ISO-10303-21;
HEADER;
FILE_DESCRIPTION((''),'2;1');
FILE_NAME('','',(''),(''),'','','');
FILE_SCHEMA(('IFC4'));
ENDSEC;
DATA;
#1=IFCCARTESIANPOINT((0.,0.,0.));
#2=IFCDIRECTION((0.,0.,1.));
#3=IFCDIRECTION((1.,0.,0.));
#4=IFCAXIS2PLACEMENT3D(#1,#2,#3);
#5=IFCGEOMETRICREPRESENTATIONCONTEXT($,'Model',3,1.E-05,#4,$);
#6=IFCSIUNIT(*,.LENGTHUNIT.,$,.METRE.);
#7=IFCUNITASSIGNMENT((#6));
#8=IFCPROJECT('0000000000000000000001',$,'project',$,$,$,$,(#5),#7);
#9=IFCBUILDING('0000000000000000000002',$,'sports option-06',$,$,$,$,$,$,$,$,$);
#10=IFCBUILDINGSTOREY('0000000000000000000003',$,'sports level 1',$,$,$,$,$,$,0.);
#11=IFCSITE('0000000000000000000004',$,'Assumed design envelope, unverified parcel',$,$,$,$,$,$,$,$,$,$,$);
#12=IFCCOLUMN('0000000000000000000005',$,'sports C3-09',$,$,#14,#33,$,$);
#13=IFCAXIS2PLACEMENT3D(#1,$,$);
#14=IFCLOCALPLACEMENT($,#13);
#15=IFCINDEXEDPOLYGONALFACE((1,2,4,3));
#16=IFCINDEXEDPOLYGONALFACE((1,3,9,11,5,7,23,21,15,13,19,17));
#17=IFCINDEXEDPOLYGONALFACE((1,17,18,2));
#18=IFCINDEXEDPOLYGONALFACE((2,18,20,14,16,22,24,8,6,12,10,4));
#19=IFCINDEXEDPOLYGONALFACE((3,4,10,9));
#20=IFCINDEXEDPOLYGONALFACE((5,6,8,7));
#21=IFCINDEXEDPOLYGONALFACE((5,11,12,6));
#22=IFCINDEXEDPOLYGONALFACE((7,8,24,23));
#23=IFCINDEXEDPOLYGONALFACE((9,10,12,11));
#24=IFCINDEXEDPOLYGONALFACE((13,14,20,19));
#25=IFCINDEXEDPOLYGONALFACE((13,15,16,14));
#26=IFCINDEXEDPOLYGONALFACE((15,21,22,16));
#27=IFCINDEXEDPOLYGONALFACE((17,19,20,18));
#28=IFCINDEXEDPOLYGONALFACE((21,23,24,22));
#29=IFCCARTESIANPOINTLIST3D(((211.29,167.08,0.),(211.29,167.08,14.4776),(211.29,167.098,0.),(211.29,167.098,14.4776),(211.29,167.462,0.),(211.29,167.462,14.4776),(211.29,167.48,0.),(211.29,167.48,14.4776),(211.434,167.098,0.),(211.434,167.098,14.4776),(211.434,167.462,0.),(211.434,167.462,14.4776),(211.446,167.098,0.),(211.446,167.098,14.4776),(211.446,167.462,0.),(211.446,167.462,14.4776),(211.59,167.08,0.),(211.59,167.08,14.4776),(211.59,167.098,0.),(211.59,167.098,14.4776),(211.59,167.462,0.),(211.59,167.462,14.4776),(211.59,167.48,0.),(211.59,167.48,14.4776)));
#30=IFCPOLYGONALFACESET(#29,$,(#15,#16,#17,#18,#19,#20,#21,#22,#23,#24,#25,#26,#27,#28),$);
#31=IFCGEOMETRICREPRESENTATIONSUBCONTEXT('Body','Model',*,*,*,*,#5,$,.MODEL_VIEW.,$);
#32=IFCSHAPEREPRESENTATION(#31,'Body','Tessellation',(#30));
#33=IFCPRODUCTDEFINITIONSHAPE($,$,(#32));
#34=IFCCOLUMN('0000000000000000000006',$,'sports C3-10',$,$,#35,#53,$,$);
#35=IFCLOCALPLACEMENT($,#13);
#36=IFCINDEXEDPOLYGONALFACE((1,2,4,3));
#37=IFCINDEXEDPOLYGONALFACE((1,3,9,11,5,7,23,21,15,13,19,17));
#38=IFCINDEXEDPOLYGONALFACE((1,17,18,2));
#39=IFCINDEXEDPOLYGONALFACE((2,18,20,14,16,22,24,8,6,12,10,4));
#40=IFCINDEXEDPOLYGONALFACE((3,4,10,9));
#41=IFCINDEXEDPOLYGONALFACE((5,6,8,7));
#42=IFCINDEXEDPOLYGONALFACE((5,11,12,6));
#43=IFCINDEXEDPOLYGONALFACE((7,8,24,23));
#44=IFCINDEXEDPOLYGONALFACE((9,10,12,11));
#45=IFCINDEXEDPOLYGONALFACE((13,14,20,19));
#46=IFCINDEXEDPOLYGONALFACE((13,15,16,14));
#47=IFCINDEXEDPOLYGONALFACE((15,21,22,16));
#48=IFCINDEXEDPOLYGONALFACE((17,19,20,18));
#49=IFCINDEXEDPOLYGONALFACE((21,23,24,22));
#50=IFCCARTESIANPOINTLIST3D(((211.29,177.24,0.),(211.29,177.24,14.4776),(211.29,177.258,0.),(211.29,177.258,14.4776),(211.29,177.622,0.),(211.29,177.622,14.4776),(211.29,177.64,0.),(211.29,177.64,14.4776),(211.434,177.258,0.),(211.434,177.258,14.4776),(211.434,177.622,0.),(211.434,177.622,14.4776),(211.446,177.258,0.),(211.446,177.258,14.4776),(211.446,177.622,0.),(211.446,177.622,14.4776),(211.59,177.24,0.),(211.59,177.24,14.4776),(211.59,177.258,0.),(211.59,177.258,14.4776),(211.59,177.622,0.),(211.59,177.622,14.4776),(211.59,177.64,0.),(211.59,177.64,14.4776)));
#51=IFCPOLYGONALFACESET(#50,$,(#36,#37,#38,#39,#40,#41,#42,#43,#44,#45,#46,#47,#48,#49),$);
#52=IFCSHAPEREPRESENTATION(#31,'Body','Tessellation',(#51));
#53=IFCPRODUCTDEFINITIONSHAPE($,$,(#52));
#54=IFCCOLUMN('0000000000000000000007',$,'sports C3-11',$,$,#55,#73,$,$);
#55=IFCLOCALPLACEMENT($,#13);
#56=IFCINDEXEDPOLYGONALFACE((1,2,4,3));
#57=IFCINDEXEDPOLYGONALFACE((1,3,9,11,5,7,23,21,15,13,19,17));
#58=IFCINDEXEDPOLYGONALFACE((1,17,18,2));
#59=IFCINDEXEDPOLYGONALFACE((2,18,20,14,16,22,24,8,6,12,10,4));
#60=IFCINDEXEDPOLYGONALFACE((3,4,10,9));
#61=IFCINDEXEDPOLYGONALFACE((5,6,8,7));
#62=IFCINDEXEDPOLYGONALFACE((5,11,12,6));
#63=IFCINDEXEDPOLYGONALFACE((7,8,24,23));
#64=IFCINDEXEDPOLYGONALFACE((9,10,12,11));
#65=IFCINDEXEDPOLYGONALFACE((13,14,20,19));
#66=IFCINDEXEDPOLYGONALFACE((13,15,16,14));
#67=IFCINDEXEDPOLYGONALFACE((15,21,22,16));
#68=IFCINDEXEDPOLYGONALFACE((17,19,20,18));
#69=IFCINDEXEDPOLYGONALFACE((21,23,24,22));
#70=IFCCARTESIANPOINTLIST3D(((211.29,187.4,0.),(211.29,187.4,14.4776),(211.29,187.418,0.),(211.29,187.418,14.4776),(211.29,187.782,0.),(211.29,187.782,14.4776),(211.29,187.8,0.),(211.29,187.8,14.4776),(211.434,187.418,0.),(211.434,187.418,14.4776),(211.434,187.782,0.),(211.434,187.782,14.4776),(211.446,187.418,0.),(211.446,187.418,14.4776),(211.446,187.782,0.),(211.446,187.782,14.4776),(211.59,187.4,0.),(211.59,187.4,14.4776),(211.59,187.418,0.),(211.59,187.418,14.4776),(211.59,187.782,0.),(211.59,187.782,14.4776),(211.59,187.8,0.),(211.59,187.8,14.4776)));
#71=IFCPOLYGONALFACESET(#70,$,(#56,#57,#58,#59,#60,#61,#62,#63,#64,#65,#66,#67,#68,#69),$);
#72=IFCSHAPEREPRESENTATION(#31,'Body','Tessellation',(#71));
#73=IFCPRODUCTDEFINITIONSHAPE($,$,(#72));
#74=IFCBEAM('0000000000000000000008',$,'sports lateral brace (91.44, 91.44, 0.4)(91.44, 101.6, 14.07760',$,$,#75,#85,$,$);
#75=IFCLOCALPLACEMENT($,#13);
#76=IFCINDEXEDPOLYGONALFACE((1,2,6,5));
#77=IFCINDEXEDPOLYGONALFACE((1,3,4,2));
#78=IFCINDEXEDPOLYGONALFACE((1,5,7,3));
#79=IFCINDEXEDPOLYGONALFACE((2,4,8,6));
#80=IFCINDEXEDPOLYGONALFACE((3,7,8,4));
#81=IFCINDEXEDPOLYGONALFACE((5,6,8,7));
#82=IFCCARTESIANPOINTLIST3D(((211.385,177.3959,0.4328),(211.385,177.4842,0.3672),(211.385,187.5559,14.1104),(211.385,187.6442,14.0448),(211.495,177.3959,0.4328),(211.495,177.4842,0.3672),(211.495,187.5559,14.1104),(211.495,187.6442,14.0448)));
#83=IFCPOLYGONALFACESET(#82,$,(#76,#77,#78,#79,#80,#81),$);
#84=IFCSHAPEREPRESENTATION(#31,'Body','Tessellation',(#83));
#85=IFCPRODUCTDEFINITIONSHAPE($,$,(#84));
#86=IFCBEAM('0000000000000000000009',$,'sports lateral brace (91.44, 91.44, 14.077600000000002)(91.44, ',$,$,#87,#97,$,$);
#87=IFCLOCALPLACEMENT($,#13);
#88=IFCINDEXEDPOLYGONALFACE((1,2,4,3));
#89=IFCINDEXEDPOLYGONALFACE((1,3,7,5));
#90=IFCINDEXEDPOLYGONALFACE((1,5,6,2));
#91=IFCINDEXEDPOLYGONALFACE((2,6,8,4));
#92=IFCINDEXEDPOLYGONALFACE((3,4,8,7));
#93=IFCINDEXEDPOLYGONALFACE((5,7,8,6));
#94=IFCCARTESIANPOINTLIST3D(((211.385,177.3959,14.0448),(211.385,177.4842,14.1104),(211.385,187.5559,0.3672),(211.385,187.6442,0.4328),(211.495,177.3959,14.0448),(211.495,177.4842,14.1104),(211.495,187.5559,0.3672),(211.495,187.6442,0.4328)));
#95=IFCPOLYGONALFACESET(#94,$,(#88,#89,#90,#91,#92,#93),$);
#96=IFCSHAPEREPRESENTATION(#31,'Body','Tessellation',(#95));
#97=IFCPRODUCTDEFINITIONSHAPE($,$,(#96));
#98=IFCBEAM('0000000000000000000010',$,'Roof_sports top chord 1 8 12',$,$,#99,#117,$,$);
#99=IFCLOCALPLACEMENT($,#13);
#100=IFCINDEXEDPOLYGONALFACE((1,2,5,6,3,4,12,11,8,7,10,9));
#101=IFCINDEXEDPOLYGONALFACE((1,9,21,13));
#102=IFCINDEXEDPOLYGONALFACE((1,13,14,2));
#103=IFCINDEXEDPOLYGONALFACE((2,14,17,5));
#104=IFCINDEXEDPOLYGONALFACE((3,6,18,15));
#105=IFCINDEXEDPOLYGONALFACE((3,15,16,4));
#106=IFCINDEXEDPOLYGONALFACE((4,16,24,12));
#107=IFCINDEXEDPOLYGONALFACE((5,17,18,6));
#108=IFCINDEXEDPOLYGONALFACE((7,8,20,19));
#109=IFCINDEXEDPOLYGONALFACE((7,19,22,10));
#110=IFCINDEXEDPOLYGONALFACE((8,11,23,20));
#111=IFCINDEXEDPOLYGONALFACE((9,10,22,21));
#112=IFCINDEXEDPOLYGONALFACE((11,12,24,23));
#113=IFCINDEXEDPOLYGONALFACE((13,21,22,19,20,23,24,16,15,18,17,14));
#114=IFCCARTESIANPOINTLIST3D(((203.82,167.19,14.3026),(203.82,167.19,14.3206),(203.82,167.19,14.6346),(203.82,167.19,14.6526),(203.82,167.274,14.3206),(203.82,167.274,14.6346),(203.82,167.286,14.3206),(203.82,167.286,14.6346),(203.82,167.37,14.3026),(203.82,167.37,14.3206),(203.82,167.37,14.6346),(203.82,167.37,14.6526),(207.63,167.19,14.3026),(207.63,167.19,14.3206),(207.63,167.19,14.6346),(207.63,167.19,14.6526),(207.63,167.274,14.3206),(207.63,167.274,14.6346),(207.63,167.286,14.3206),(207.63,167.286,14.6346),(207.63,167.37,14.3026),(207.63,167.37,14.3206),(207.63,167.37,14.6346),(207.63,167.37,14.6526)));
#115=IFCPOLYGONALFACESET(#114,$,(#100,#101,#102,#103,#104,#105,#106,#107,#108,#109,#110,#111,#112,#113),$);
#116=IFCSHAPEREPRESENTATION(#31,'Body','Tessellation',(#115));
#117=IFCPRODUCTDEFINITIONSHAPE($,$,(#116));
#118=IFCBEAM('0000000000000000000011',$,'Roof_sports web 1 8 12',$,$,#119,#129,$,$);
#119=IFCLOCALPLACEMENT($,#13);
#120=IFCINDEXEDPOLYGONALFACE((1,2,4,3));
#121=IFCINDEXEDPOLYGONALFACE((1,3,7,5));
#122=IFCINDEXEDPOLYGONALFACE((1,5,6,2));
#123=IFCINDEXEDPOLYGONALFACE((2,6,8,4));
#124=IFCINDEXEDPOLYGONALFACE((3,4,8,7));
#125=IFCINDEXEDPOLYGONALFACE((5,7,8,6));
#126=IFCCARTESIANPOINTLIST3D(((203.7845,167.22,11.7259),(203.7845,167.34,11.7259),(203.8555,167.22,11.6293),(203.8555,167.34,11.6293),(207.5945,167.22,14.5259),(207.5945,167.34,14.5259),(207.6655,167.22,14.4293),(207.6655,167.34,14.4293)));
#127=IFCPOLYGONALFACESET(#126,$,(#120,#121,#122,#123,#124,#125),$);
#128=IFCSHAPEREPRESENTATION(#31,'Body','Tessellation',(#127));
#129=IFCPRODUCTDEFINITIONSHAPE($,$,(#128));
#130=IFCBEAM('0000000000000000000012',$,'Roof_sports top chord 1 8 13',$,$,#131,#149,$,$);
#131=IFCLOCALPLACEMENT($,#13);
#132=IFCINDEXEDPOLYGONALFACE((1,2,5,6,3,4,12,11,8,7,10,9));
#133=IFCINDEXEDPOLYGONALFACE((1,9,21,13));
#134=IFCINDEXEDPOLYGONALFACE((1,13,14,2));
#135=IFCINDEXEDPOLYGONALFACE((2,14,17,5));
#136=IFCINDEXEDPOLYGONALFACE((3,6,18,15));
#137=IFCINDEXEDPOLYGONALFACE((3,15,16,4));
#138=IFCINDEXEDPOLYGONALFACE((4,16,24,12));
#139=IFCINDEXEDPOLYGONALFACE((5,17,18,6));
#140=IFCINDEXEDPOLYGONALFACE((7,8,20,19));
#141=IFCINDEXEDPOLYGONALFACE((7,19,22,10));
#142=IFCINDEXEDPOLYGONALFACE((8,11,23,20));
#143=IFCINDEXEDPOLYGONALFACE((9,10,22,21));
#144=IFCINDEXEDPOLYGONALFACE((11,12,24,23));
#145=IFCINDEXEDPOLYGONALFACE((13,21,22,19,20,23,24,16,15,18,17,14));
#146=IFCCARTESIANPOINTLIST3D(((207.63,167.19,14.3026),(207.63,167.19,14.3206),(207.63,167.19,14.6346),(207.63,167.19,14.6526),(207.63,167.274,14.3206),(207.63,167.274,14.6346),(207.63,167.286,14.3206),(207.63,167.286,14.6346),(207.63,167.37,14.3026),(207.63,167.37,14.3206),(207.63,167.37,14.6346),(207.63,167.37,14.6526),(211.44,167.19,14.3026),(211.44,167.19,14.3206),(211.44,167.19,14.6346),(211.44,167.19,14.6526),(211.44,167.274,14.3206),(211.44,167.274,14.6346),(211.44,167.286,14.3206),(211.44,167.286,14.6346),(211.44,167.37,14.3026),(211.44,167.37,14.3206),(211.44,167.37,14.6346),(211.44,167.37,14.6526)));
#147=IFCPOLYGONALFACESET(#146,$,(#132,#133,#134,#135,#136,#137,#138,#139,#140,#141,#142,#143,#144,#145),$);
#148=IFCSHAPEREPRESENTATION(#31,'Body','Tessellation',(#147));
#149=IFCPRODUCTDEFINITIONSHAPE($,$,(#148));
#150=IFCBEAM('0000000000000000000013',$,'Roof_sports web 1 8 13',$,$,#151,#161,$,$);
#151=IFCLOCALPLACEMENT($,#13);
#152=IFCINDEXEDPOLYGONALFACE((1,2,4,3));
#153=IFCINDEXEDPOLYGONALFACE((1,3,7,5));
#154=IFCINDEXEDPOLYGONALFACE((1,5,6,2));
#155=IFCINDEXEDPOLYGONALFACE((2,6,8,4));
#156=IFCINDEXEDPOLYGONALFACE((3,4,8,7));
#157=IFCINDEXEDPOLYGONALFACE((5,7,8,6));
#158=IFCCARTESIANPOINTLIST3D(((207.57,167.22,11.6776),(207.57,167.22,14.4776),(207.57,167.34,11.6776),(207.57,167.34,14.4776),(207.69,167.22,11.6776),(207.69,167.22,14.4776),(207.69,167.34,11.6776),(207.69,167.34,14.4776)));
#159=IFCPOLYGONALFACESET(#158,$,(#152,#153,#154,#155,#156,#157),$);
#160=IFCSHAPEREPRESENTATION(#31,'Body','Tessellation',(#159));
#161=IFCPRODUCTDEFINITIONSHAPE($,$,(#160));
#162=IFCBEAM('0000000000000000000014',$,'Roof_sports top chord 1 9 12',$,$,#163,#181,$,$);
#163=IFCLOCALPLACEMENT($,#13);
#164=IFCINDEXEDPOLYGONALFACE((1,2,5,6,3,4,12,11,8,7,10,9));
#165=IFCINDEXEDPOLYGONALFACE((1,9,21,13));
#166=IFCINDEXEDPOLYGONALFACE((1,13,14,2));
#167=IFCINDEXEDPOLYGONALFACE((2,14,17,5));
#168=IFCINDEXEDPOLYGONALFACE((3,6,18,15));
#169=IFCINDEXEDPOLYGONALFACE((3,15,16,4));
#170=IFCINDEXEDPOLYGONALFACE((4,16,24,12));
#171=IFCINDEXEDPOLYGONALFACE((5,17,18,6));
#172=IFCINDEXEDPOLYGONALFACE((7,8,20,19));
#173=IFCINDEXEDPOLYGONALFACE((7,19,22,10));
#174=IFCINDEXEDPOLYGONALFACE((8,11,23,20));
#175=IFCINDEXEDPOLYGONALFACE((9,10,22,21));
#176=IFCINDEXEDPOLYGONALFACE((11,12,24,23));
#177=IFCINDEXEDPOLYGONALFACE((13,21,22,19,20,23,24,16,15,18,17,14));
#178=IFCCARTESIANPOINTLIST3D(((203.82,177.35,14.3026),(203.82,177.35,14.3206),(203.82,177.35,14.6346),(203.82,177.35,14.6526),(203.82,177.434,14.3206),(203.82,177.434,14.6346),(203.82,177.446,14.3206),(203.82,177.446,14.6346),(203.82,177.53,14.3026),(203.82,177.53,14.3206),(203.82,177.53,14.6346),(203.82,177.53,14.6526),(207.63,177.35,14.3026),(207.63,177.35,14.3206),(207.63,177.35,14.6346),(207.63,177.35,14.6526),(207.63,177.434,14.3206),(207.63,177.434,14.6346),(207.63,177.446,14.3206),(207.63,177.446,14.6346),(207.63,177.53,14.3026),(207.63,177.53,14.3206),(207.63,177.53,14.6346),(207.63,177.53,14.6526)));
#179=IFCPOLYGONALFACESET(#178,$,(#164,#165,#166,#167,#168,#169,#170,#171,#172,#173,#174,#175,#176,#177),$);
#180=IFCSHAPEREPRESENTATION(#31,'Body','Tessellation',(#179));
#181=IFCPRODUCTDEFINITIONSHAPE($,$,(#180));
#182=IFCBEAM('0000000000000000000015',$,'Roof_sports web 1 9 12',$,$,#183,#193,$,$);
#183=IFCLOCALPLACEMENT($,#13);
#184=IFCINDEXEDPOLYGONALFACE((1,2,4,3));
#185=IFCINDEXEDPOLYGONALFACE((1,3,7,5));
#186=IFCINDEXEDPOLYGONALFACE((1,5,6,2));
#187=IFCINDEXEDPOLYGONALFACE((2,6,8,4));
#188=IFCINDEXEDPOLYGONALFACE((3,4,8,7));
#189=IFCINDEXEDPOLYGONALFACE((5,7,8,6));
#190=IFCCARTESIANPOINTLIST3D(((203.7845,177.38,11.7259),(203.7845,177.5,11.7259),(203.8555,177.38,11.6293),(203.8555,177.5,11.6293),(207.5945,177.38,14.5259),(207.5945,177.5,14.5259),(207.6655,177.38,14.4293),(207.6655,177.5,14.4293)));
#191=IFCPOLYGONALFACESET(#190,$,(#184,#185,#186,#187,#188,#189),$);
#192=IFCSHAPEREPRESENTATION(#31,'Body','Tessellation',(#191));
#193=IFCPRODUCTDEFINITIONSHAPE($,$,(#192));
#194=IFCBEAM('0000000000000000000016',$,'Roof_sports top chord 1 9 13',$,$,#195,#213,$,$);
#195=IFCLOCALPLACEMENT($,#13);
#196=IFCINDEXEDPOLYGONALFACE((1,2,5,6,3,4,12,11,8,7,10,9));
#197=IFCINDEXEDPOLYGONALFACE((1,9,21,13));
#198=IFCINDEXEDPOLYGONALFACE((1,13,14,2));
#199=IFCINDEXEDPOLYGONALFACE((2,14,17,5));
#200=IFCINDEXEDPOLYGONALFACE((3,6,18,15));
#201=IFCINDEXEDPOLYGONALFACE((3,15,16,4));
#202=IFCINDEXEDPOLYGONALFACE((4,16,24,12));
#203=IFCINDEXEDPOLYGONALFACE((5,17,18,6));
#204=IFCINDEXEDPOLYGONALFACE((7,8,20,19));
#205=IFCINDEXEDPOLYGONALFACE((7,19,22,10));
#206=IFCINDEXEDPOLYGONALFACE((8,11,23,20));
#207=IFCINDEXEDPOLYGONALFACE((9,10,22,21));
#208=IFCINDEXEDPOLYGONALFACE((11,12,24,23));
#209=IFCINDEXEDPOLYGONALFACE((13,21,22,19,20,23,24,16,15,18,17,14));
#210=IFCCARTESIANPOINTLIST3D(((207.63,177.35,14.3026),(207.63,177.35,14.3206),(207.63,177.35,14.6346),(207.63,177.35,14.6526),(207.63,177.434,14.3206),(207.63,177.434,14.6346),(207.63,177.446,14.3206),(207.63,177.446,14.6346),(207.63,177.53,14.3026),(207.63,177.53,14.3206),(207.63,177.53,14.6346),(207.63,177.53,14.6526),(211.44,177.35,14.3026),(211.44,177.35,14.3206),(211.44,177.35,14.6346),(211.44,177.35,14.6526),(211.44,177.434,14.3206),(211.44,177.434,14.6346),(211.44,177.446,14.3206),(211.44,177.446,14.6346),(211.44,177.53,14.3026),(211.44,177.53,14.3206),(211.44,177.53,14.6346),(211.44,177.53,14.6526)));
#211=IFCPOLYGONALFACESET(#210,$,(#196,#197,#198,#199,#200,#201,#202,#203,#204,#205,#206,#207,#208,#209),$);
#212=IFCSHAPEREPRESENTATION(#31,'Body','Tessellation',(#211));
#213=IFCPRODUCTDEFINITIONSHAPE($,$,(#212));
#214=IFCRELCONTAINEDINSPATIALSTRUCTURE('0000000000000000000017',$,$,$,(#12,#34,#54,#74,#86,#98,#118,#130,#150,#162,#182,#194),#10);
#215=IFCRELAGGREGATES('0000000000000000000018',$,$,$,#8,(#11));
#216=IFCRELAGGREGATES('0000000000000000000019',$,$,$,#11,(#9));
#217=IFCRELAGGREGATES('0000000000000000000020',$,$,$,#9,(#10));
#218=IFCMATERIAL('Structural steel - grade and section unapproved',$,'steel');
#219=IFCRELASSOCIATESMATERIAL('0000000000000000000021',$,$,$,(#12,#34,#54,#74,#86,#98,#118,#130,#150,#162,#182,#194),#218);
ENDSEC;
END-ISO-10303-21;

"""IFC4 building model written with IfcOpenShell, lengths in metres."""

from ifc_helpers import new_model, si_unit, frame, origin_with_axes, place, context, subcontext, project, spatial, rectangle, i_section, extrude, material, element, save


model = new_model("IFC4")

# Units and contexts
model_context = context("Model", 3, precision=1e-05, world=origin_with_axes())
body_context = subcontext(model_context, "Body", "Model", "MODEL_VIEW")
ifc_project = project(units=[si_unit("LENGTHUNIT", "METRE")], contexts=[model_context])

# Site, building, storey
site = spatial("IfcSite", under=ifc_project, Name="Assumed design envelope, unverified parcel")
building = spatial("IfcBuilding", under=site, Name="sports option-06")
storey = spatial("IfcBuildingStorey", under=building, Name="sports level 1", Elevation=0.0)

# Columns
ifc_material_1 = material(Name="Structural steel - grade and section unapproved", Category="steel")
for number, where, z_axis, x_axis, name in (
    (1, (211.44, 167.28, 0.0), (0.0, 0.0, 1.0), (-1.0, 0.0, 0.0), "sports C3-09"),
    (2, (211.44, 177.44, 0.0), (0.0, 0.0, 1.0), (-1.0, 0.0, 0.0), "sports C3-10"),
    (3, (211.44, 187.6, 0.0), (0.0, 0.0, 1.0), (-1.0, 0.0, 0.0), "sports C3-11"),
):
    element("IfcColumn", number, at=place(None, frame(where, z_axis=z_axis, x_axis=x_axis)), inside=storey, material=ifc_material_1, Name=name, context=body_context, shape_type="SweptSolid", body=[
        extrude(i_section(OverallWidth=0.3, OverallDepth=0.4, WebThickness=0.012, FlangeThickness=0.018, FilletRadius=0.0), origin_with_axes(), (0.0, 0.0, 1.0), 14.4776),
    ])

# Beams
for number, where, z_axis, x_axis, name in (
    (4, (211.44, 177.44, 0.4), (0.0, 0.596305, 0.802758), (-1.0, 0.0, 0.0), "sports lateral brace (91.44, 91.44, 0.4)(91.44, 101.6, 14.07760"),
    (5, (211.44, 177.44, 14.0776), (0.0, 0.596305, -0.802758), (-1.0, 0.0, 0.0), "sports lateral brace (91.44, 91.44, 14.077600000000002)(91.44, "),
):
    element("IfcBeam", number, at=place(None, frame(where, z_axis=z_axis, x_axis=x_axis)), inside=storey, material=ifc_material_1, Name=name, context=body_context, shape_type="SweptSolid", body=[
        extrude(rectangle(XDim=0.11, YDim=0.11), origin_with_axes(), (0.0, 0.0, 1.0), 17.0383),
    ])
beam_1_placement = place(None, frame((203.82, 167.28, 14.4776), z_axis=(1.0, 0.0, 0.0), x_axis=(0.0, 1.0, 0.0)))
element("IfcBeam", 6, at=beam_1_placement, inside=storey, material=ifc_material_1, Name="Roof_sports top chord 1 8 12", context=body_context, shape_type="SweptSolid", body=[
    extrude(i_section(OverallWidth=0.18, OverallDepth=0.35, WebThickness=0.012, FlangeThickness=0.018, FilletRadius=0.0), origin_with_axes(), (0.0, 0.0, 1.0), 3.81),
])
beam_2_placement = place(None, frame((203.82, 167.28, 11.6776), z_axis=(0.805799, 0.0, 0.592189), x_axis=(0.0, 1.0, 0.0)))
element("IfcBeam", 7, at=beam_2_placement, inside=storey, material=ifc_material_1, Name="Roof_sports web 1 8 12", context=body_context, shape_type="SweptSolid", body=[
    extrude(rectangle(XDim=0.12, YDim=0.12), origin_with_axes(), (0.0, 0.0, 1.0), 4.7282),
])
beam_3_placement = place(None, frame((207.63, 167.28, 14.4776), z_axis=(1.0, 0.0, 0.0), x_axis=(0.0, 1.0, 0.0)))
element("IfcBeam", 8, at=beam_3_placement, inside=storey, material=ifc_material_1, Name="Roof_sports top chord 1 8 13", context=body_context, shape_type="SweptSolid", body=[
    extrude(i_section(OverallWidth=0.18, OverallDepth=0.35, WebThickness=0.012, FlangeThickness=0.018, FilletRadius=0.0), origin_with_axes(), (0.0, 0.0, 1.0), 3.81),
])
beam_4_placement = place(None, frame((207.63, 167.28, 11.6776), z_axis=(0.0, 0.0, 1.0), x_axis=(-1.0, 0.0, 0.0)))
element("IfcBeam", 9, at=beam_4_placement, inside=storey, material=ifc_material_1, Name="Roof_sports web 1 8 13", context=body_context, shape_type="SweptSolid", body=[
    extrude(rectangle(XDim=0.12, YDim=0.12), origin_with_axes(), (0.0, 0.0, 1.0), 2.8),
])
beam_5_placement = place(None, frame((203.82, 177.44, 14.4776), z_axis=(1.0, 0.0, 0.0), x_axis=(0.0, 1.0, 0.0)))
element("IfcBeam", 10, at=beam_5_placement, inside=storey, material=ifc_material_1, Name="Roof_sports top chord 1 9 12", context=body_context, shape_type="SweptSolid", body=[
    extrude(i_section(OverallWidth=0.18, OverallDepth=0.35, WebThickness=0.012, FlangeThickness=0.018, FilletRadius=0.0), origin_with_axes(), (0.0, 0.0, 1.0), 3.81),
])
beam_6_placement = place(None, frame((203.82, 177.44, 11.6776), z_axis=(0.805799, 0.0, 0.592189), x_axis=(0.0, 1.0, 0.0)))
element("IfcBeam", 11, at=beam_6_placement, inside=storey, material=ifc_material_1, Name="Roof_sports web 1 9 12", context=body_context, shape_type="SweptSolid", body=[
    extrude(rectangle(XDim=0.12, YDim=0.12), origin_with_axes(), (0.0, 0.0, 1.0), 4.7282),
])
beam_7_placement = place(None, frame((207.63, 177.44, 14.4776), z_axis=(1.0, 0.0, 0.0), x_axis=(0.0, 1.0, 0.0)))
element("IfcBeam", 12, at=beam_7_placement, inside=storey, material=ifc_material_1, Name="Roof_sports top chord 1 9 13", context=body_context, shape_type="SweptSolid", body=[
    extrude(i_section(OverallWidth=0.18, OverallDepth=0.35, WebThickness=0.012, FlangeThickness=0.018, FilletRadius=0.0), origin_with_axes(), (0.0, 0.0, 1.0), 3.81),
])

save(model, "model.ifc")
